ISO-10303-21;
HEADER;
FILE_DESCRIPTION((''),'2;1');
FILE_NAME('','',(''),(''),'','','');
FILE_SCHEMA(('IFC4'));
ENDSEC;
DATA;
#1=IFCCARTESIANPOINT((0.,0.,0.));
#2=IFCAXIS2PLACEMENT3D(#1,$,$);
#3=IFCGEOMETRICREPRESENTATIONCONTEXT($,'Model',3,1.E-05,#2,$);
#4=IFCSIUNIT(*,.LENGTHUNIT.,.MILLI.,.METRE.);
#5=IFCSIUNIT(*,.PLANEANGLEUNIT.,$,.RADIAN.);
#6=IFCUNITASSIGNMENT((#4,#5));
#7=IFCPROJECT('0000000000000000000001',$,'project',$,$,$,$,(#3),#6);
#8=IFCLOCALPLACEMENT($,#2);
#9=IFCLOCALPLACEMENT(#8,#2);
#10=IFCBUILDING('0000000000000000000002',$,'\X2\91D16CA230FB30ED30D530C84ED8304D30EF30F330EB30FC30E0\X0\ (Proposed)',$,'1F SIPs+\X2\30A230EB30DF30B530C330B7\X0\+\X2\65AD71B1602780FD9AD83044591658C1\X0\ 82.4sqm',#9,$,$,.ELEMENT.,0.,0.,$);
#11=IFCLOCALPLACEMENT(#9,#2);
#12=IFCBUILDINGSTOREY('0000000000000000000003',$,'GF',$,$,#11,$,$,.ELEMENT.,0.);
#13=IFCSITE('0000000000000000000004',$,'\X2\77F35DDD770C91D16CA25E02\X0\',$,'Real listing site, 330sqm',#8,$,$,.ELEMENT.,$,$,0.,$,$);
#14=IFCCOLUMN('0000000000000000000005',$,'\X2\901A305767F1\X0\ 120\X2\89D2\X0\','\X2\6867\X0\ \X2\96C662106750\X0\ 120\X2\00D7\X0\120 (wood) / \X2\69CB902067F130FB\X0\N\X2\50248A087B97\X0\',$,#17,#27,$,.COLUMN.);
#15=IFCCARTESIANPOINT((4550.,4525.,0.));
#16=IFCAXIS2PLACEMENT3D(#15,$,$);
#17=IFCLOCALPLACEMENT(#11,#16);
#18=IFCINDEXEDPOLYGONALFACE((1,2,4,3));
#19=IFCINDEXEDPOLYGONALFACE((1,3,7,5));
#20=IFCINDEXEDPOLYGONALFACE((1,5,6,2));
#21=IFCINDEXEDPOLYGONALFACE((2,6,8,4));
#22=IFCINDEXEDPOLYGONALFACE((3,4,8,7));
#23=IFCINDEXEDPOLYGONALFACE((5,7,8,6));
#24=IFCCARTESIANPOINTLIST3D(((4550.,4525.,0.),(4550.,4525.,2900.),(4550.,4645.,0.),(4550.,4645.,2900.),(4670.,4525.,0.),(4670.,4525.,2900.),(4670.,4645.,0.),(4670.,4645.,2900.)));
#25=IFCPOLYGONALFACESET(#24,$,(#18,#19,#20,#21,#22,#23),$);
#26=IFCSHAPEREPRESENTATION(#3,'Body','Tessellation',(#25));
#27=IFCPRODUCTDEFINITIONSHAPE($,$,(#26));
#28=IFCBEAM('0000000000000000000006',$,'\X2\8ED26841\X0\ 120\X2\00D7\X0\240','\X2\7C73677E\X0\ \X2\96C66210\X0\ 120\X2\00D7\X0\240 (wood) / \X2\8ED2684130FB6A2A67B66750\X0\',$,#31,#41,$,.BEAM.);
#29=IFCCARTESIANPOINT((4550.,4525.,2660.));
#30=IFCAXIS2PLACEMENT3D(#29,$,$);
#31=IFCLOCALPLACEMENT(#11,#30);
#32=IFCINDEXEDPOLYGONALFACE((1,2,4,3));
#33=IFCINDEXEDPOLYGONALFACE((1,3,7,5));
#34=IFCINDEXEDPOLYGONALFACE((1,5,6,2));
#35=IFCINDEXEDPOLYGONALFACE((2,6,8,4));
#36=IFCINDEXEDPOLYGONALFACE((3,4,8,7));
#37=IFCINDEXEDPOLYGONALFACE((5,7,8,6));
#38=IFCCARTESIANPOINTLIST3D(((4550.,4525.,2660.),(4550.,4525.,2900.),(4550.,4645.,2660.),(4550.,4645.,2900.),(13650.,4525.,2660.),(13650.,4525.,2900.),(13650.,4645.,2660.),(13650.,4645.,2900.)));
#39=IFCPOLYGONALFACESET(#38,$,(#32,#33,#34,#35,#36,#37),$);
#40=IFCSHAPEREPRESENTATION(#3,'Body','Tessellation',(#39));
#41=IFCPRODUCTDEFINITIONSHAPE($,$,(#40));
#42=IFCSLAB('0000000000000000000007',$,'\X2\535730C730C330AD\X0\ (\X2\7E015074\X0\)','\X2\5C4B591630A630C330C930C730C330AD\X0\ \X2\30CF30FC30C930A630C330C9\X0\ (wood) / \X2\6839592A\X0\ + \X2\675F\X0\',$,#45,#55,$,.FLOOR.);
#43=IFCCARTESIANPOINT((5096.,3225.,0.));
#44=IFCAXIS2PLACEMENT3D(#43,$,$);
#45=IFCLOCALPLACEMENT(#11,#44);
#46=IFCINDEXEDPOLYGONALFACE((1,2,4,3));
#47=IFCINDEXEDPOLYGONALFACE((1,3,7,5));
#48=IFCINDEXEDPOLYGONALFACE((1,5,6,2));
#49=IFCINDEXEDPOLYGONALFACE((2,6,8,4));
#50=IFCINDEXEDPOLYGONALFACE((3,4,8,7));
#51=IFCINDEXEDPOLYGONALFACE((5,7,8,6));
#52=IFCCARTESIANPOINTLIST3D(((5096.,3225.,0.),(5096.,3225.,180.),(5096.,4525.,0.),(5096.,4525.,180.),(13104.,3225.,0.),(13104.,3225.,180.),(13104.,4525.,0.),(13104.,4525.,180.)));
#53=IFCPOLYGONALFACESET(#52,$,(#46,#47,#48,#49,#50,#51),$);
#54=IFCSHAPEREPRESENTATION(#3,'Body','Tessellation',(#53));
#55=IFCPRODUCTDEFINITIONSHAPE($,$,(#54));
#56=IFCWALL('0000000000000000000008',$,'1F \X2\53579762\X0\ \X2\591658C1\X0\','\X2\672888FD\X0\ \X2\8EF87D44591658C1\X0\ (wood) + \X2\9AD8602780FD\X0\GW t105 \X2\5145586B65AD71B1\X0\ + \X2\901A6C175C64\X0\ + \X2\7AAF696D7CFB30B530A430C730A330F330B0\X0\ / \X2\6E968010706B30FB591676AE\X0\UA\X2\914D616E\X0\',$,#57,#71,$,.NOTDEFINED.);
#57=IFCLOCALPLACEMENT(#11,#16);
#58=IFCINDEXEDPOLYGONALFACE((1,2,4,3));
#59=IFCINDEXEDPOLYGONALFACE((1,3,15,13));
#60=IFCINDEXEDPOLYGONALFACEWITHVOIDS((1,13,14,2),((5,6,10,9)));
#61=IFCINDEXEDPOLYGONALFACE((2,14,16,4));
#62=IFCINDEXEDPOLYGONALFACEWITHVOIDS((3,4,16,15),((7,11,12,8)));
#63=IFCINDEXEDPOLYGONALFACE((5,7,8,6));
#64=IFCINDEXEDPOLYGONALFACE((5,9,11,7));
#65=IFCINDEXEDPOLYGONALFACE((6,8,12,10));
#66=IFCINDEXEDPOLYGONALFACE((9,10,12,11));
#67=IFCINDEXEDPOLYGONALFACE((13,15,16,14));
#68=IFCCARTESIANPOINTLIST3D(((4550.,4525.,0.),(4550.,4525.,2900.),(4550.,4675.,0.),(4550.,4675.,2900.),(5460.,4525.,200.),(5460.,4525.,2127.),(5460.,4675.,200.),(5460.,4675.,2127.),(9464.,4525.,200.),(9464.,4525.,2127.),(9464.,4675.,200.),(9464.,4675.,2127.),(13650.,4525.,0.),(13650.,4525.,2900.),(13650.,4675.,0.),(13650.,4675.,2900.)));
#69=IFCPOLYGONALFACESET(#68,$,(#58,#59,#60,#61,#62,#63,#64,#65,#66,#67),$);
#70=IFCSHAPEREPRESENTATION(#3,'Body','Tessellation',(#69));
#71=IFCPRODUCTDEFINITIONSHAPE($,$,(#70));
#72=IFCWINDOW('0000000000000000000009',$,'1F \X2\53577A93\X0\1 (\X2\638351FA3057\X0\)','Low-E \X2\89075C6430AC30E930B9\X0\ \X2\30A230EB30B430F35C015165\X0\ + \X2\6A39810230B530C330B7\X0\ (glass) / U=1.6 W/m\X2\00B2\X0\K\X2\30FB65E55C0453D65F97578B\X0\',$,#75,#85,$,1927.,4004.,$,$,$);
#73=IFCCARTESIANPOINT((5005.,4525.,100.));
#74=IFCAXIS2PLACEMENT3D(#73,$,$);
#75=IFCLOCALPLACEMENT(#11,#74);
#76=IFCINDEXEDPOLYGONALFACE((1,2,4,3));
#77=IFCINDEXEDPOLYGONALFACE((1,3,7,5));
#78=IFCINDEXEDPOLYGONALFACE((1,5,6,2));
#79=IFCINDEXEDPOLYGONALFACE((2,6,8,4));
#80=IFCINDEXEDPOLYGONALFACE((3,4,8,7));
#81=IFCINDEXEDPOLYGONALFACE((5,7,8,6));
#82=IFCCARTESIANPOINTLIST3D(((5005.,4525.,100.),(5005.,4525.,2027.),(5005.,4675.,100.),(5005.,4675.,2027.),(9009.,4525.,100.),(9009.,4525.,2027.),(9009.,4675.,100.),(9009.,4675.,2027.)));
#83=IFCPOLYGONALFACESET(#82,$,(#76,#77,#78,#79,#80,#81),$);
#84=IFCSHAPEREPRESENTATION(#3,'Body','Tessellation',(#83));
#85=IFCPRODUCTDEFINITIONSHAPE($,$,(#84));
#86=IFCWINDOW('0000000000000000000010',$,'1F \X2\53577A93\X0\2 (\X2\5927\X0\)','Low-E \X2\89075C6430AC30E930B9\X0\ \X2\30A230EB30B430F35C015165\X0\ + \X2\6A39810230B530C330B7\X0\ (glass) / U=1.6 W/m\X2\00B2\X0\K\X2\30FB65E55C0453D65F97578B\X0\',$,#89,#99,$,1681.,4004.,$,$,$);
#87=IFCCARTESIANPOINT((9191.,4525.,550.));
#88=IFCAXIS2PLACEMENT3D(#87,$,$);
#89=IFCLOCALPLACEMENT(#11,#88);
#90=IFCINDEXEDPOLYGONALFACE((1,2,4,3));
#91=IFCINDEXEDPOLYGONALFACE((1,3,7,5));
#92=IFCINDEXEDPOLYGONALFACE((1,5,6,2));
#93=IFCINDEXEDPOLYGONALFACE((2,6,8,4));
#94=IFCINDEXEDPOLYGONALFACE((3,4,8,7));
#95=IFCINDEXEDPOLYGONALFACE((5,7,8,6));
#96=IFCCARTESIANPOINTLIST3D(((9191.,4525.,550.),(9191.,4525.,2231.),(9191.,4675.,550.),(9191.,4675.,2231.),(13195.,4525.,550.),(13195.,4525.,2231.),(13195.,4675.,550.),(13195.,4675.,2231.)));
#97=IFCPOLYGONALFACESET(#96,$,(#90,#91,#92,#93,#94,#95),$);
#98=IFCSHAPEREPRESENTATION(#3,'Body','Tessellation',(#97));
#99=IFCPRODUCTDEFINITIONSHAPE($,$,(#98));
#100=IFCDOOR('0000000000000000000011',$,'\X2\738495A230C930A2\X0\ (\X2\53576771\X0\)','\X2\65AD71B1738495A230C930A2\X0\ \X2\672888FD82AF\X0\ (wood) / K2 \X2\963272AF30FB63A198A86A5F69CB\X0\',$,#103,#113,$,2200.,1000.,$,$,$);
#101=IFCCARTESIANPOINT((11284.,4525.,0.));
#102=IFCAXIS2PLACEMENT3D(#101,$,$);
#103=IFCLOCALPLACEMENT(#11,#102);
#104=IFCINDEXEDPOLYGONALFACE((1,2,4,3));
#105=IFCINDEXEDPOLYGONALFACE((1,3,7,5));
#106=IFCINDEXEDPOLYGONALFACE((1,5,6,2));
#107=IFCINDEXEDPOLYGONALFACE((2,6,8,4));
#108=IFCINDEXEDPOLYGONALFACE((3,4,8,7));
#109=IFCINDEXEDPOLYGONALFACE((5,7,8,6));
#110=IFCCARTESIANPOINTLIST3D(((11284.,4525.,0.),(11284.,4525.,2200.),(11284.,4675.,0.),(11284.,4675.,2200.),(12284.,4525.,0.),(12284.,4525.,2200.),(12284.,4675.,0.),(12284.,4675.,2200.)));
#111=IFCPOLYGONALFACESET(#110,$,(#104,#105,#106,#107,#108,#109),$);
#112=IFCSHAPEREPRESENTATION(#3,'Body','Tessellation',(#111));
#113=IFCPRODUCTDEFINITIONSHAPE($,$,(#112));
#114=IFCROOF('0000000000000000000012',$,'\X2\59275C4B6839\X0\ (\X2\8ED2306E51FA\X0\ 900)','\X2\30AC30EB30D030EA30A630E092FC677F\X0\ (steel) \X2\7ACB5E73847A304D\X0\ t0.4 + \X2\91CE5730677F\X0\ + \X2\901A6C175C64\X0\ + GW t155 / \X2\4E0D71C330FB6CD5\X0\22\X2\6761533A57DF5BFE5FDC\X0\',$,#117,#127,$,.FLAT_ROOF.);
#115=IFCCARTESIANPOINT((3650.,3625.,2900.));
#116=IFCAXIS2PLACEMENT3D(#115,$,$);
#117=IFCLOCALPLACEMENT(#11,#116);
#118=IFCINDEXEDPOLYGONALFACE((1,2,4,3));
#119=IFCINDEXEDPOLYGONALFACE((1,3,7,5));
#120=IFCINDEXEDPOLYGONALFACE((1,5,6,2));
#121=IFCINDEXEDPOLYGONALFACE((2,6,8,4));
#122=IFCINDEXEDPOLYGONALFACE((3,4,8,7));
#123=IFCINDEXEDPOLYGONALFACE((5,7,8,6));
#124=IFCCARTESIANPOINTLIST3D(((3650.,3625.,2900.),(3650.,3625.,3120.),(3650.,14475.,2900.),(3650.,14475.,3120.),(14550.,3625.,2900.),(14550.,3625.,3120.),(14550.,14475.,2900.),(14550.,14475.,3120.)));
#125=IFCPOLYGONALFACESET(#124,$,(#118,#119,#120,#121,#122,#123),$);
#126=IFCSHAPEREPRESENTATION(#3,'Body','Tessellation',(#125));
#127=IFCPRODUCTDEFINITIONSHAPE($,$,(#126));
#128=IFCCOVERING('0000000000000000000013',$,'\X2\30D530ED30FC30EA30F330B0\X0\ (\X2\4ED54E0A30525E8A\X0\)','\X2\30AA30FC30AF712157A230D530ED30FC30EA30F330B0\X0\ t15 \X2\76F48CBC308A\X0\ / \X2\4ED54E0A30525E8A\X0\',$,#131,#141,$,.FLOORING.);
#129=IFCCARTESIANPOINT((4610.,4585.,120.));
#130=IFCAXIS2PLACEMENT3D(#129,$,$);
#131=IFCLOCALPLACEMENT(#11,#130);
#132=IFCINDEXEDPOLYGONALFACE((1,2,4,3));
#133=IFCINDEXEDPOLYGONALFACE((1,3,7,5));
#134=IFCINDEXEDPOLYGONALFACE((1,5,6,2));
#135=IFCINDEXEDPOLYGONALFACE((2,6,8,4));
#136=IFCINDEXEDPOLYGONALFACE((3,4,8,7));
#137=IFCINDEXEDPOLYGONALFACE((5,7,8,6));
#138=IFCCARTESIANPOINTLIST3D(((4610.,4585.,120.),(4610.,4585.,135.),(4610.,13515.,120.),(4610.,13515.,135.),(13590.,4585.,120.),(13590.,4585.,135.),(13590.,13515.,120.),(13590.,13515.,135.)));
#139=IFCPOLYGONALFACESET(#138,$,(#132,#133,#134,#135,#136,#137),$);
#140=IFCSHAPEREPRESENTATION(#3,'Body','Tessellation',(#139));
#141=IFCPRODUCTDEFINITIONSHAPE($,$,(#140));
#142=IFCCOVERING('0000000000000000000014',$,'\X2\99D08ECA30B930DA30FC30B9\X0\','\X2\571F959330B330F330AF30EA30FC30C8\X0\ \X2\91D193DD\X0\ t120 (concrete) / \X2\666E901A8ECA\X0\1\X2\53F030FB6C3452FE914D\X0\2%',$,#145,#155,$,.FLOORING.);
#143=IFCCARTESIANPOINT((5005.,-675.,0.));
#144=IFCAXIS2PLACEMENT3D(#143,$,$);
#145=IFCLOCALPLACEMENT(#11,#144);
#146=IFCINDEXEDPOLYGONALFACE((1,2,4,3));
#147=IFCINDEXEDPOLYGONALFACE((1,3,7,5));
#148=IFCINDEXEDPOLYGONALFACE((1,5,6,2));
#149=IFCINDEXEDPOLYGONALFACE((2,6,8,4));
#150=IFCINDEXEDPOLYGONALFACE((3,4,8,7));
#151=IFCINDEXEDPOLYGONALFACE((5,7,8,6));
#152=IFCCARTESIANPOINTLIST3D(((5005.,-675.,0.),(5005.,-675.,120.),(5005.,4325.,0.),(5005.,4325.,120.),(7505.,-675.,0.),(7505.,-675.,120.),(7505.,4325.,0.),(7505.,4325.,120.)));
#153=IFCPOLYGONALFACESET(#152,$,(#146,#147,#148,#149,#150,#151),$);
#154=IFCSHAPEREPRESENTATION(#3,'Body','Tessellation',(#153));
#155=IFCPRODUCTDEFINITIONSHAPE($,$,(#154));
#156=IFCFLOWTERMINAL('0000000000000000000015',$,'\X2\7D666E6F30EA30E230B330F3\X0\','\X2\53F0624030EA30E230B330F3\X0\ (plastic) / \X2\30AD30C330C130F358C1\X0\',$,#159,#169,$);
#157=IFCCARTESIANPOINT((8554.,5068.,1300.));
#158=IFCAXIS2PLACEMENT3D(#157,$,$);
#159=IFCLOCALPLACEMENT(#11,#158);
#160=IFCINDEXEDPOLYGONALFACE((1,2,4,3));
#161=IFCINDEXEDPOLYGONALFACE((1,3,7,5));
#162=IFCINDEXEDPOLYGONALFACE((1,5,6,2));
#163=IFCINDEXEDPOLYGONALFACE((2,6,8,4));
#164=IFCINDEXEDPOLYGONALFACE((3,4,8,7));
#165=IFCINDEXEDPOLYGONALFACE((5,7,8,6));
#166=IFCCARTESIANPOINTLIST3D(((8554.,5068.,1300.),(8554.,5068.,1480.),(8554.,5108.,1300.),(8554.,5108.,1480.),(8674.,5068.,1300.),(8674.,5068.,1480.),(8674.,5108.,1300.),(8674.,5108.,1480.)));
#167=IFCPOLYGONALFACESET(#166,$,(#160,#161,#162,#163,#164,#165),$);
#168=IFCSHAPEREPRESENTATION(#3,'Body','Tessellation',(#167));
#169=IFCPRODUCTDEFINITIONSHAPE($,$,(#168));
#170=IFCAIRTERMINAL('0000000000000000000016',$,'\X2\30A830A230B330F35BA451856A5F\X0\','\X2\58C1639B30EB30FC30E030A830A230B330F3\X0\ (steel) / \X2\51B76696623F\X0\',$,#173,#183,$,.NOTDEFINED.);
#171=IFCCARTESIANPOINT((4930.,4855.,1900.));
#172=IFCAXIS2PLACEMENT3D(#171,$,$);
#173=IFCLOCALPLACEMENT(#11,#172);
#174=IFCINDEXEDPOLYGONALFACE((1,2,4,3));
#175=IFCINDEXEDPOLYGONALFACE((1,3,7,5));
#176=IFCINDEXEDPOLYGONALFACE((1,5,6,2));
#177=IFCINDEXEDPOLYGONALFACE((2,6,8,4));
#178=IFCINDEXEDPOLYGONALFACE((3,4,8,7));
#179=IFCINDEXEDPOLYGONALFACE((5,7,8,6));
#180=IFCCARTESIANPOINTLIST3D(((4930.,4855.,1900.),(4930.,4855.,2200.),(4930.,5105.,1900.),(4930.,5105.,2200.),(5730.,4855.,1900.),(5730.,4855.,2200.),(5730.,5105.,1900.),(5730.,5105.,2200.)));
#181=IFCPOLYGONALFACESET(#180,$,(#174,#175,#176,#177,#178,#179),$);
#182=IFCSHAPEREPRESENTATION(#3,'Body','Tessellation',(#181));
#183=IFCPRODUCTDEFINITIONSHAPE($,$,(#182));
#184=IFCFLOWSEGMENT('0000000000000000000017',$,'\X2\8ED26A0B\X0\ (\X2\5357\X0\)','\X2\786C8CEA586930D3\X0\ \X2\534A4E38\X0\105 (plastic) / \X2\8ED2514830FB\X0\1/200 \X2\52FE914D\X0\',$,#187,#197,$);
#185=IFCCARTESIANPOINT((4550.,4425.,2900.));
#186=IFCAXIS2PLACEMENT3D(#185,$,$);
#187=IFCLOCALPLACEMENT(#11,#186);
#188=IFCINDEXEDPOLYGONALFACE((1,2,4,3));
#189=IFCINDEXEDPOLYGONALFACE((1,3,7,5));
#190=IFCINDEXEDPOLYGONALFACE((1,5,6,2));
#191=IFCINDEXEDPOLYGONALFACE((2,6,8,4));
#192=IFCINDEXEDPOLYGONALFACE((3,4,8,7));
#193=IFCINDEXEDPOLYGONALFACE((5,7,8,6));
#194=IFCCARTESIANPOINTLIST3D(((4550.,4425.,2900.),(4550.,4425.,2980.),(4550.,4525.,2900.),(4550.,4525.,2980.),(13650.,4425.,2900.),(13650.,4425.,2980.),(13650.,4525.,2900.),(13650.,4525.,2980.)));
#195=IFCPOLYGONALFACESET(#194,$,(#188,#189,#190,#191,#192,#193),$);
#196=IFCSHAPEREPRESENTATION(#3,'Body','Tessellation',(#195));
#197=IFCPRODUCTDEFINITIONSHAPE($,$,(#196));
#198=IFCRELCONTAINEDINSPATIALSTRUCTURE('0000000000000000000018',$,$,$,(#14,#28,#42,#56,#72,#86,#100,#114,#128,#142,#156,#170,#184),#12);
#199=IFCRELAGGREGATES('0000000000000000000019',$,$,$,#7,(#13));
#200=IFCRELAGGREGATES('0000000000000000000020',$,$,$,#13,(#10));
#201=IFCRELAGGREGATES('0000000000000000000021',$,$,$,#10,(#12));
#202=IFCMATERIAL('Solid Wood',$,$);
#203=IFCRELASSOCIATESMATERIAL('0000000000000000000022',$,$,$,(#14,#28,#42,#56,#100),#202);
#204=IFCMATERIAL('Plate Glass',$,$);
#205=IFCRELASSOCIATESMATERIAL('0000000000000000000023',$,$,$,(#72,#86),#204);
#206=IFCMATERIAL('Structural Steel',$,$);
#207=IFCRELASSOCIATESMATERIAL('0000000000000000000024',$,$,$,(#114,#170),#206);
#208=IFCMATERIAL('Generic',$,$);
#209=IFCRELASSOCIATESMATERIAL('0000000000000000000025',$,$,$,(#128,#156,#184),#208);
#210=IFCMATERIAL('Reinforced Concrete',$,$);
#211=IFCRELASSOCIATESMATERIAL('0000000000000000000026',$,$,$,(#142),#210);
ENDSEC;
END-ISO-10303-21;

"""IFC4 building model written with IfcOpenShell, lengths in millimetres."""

from ifc_helpers import new_model, si_unit, frame, frame_2d, origin, place, context, project, spatial, rectangle, extrude, material, element, fill, save


model = new_model("IFC4")

# Units and contexts
model_context = context("Model", 3, precision=1e-05, world=origin())
ifc_project = project(units=[si_unit("LENGTHUNIT", "METRE", prefix="MILLI"), si_unit("PLANEANGLEUNIT", "RADIAN")], contexts=[model_context])

# Site, building, storey
site_placement = place(None, origin())
site = spatial("IfcSite", under=ifc_project, at=site_placement, Name="石川県金沢市", ObjectType="Real listing site, 330sqm", CompositionType="ELEMENT", RefElevation=0.0)
building_placement = place(site_placement, origin())
building = spatial("IfcBuilding", under=site, at=building_placement, Name="金沢・ロフト付きワンルーム (Proposed)", ObjectType="1F SIPs+アルミサッシ+断熱性能高い外壁 82.4sqm", CompositionType="ELEMENT", ElevationOfRefHeight=0.0, ElevationOfTerrain=0.0)
storey_placement = place(building_placement, origin())
storey = spatial("IfcBuildingStorey", under=building, at=storey_placement, Name="GF", CompositionType="ELEMENT", Elevation=0.0)

# Column
ifc_material_1 = material(Name="Solid Wood")
column_1_placement = place(storey_placement, frame((4550.0, 4525.0, 0.0)))
element("IfcColumn", 1, at=column_1_placement, inside=storey, material=ifc_material_1, Name="通し柱 120角", Description="桧 集成材 120×120 (wood) / 構造柱・N値計算", PredefinedType="COLUMN", context=model_context, shape_type="SweptSolid", body=[
    extrude(rectangle(XDim=120.0, YDim=120.0, at=frame_2d((60.0, 60.0))), frame((4550.0, 4525.0, 0.0)), (0.0, 0.0, 1.0), 2900.0),
])

# Beam
beam_1_placement = place(storey_placement, frame((4550.0, 4525.0, 2660.0)))
element("IfcBeam", 2, at=beam_1_placement, inside=storey, material=ifc_material_1, Name="軒桁 120×240", Description="米松 集成 120×240 (wood) / 軒桁・横架材", PredefinedType="BEAM", context=model_context, shape_type="SweptSolid", body=[
    extrude(rectangle(XDim=9100.0, YDim=120.0, at=frame_2d((4550.0, 60.0))), frame((4550.0, 4525.0, 2660.0)), (0.0, 0.0, 1.0), 240.0),
])

# Slab
ifc_material_2 = material(Name="Reinforced Concrete")
slab_1_placement = place(storey_placement, frame((5096.0, 3225.0, 0.0)))
element("IfcSlab", 3, at=slab_1_placement, inside=storey, material=ifc_material_1, Name="南デッキ (縁側)", Description="屋外ウッドデッキ ハードウッド (wood) / 根太 + 束", PredefinedType="FLOOR", context=model_context, shape_type="SweptSolid", body=[
    extrude(rectangle(XDim=8008.0, YDim=1300.0, at=frame_2d((4004.0, 650.0))), frame((5096.0, 3225.0, 0.0)), (0.0, 0.0, 1.0), 180.0),
])

# Wall, openings, windows, door
wall_1_placement = place(storey_placement, frame((4550.0, 4525.0, 0.0)))
wall_1 = element("IfcWall", 4, at=wall_1_placement, inside=storey, material=ifc_material_1, Name="1F 南面 外壁", Description="木製 軸組外壁 (wood) + 高性能GW t105 充填断熱 + 通気層 + 窯業系サイディング / 準耐火・外皮UA配慮", PredefinedType="NOTDEFINED", context=model_context, shape_type="SweptSolid", body=[
    extrude(rectangle(XDim=9100.0, YDim=150.0, at=frame_2d((4550.0, 75.0))), frame((4550.0, 4525.0, 0.0)), (0.0, 0.0, 1.0), 2900.0),
])
opening_1_placement = place(storey_placement, frame((5005.0, 4525.0, 100.0)))
opening_1 = element("IfcOpeningElement", 5, at=opening_1_placement, cuts=wall_1, PredefinedType="NOTDEFINED", context=model_context, shape_type="SweptSolid", body=[
    extrude(rectangle(XDim=4004.0, YDim=150.0, at=frame_2d((2002.0, 75.0))), frame((5005.0, 4525.0, 100.0)), (0.0, 0.0, 1.0), 1927.0),
])
opening_2_placement = place(storey_placement, frame((9191.0, 4525.0, 550.0)))
opening_2 = element("IfcOpeningElement", 6, at=opening_2_placement, cuts=wall_1, PredefinedType="NOTDEFINED", context=model_context, shape_type="SweptSolid", body=[
    extrude(rectangle(XDim=4004.0, YDim=150.0, at=frame_2d((2002.0, 75.0))), frame((9191.0, 4525.0, 550.0)), (0.0, 0.0, 1.0), 1681.0),
])
opening_3_placement = place(storey_placement, frame((11284.0, 4525.0, 0.0)))
opening_3 = element("IfcOpeningElement", 7, at=opening_3_placement, cuts=wall_1, PredefinedType="NOTDEFINED", context=model_context, shape_type="SweptSolid", body=[
    extrude(rectangle(XDim=1000.0, YDim=150.0, at=frame_2d((500.0, 75.0))), frame((11284.0, 4525.0, 0.0)), (0.0, 0.0, 1.0), 2200.0),
])
ifc_material_3 = material(Name="Plate Glass")
window_1_placement = place(storey_placement, frame((5005.0, 4525.0, 100.0)))
window_1 = element("IfcWindow", 8, at=window_1_placement, inside=storey, material=ifc_material_3, Name="1F 南窓1 (掃出し)", Description="Low-E 複層ガラス アルゴン封入 + 樹脂サッシ (glass) / U=1.6 W/m²K・日射取得型", OverallHeight=1927.0, OverallWidth=4004.0, context=model_context, shape_type="SweptSolid", body=[
    extrude(rectangle(XDim=4004.0, YDim=150.0, at=frame_2d((2002.0, 75.0))), frame((5005.0, 4525.0, 100.0)), (0.0, 0.0, 1.0), 1927.0),
])
fill(opening_1, window_1)
window_2_placement = place(storey_placement, frame((9191.0, 4525.0, 550.0)))
window_2 = element("IfcWindow", 9, at=window_2_placement, inside=storey, material=ifc_material_3, Name="1F 南窓2 (大)", Description="Low-E 複層ガラス アルゴン封入 + 樹脂サッシ (glass) / U=1.6 W/m²K・日射取得型", OverallHeight=1681.0, OverallWidth=4004.0, context=model_context, shape_type="SweptSolid", body=[
    extrude(rectangle(XDim=4004.0, YDim=150.0, at=frame_2d((2002.0, 75.0))), frame((9191.0, 4525.0, 550.0)), (0.0, 0.0, 1.0), 1681.0),
])
fill(opening_2, window_2)
door_placement = place(storey_placement, frame((11284.0, 4525.0, 0.0)))
door = element("IfcDoor", 10, at=door_placement, inside=storey, material=ifc_material_1, Name="玄関ドア (南東)", Description="断熱玄関ドア 木製芯 (wood) / K2 防犯・採風機構", OverallHeight=2200.0, OverallWidth=1000.0, context=model_context, shape_type="SweptSolid", body=[
    extrude(rectangle(XDim=1000.0, YDim=150.0, at=frame_2d((500.0, 75.0))), frame((11284.0, 4525.0, 0.0)), (0.0, 0.0, 1.0), 2200.0),
])
fill(opening_3, door)

# Roof
ifc_material_4 = material(Name="Structural Steel")
roof_placement = place(storey_placement, frame((3650.0, 3625.0, 2900.0)))
element("IfcRoof", 11, at=roof_placement, inside=storey, material=ifc_material_4, Name="大屋根 (軒の出 900)", Description="ガルバリウム鋼板 (steel) 立平葺き t0.4 + 野地板 + 通気層 + GW t155 / 不燃・法22条区域対応", PredefinedType="FLAT_ROOF", context=model_context, shape_type="SweptSolid", body=[
    extrude(rectangle(XDim=10900.0, YDim=10850.0, at=frame_2d((5450.0, 5425.0))), frame((3650.0, 3625.0, 2900.0)), (0.0, 0.0, 1.0), 220.0),
])

# Coverings
ifc_material_5 = material(Name="Generic")
covering_1_placement = place(storey_placement, frame((4610.0, 4585.0, 120.0)))
element("IfcCovering", 12, at=covering_1_placement, inside=storey, material=ifc_material_5, Name="フローリング (仕上げ床)", Description="オーク無垢フローリング t15 直貼り / 仕上げ床", PredefinedType="FLOORING", context=model_context, shape_type="SweptSolid", body=[
    extrude(rectangle(XDim=8980.0, YDim=8930.0, at=frame_2d((4490.0, 4465.0))), frame((4610.0, 4585.0, 120.0)), (0.0, 0.0, 1.0), 15.0),
])
covering_2_placement = place(storey_placement, frame((5005.0, -675.0, 0.0)))
element("IfcCovering", 13, at=covering_2_placement, inside=storey, material=ifc_material_2, Name="駐車スペース", Description="土間コンクリート 金鏝 t120 (concrete) / 普通車1台・水勾配2%", PredefinedType="FLOORING", context=model_context, shape_type="SweptSolid", body=[
    extrude(rectangle(XDim=2500.0, YDim=5000.0, at=frame_2d((1250.0, 2500.0))), frame((5005.0, -675.0, 0.0)), (0.0, 0.0, 1.0), 120.0),
])

# Flow terminal
flow_terminal_placement = place(storey_placement, frame((8554.0, 5068.0, 1300.0)))
element("IfcFlowTerminal", 14, at=flow_terminal_placement, inside=storey, material=ifc_material_5, Name="給湯リモコン", Description="台所リモコン (plastic) / キッチン壁", context=model_context, shape_type="SweptSolid", body=[
    extrude(rectangle(XDim=120.0, YDim=40.0, at=frame_2d((60.0, 20.0))), frame((8554.0, 5068.0, 1300.0)), (0.0, 0.0, 1.0), 180.0),
])

# Air terminal
air_terminal_placement = place(storey_placement, frame((4930.0, 4855.0, 1900.0)))
element("IfcAirTerminal", 15, at=air_terminal_placement, inside=storey, material=ifc_material_4, Name="エアコン室内機", Description="壁掛ルームエアコン (steel) / 冷暖房", PredefinedType="NOTDEFINED", context=model_context, shape_type="SweptSolid", body=[
    extrude(rectangle(XDim=800.0, YDim=250.0, at=frame_2d((400.0, 125.0))), frame((4930.0, 4855.0, 1900.0)), (0.0, 0.0, 1.0), 300.0),
])

# Flow segment
flow_segment_1_placement = place(storey_placement, frame((4550.0, 4425.0, 2900.0)))
element("IfcFlowSegment", 16, at=flow_segment_1_placement, inside=storey, material=ifc_material_5, Name="軒樋 (南)", Description="硬質塩ビ 半丸105 (plastic) / 軒先・1/200 勾配", context=model_context, shape_type="SweptSolid", body=[
    extrude(rectangle(XDim=9100.0, YDim=100.0, at=frame_2d((4550.0, 50.0))), frame((4550.0, 4425.0, 2900.0)), (0.0, 0.0, 1.0), 80.0),
])

save(model, "model.ifc")
